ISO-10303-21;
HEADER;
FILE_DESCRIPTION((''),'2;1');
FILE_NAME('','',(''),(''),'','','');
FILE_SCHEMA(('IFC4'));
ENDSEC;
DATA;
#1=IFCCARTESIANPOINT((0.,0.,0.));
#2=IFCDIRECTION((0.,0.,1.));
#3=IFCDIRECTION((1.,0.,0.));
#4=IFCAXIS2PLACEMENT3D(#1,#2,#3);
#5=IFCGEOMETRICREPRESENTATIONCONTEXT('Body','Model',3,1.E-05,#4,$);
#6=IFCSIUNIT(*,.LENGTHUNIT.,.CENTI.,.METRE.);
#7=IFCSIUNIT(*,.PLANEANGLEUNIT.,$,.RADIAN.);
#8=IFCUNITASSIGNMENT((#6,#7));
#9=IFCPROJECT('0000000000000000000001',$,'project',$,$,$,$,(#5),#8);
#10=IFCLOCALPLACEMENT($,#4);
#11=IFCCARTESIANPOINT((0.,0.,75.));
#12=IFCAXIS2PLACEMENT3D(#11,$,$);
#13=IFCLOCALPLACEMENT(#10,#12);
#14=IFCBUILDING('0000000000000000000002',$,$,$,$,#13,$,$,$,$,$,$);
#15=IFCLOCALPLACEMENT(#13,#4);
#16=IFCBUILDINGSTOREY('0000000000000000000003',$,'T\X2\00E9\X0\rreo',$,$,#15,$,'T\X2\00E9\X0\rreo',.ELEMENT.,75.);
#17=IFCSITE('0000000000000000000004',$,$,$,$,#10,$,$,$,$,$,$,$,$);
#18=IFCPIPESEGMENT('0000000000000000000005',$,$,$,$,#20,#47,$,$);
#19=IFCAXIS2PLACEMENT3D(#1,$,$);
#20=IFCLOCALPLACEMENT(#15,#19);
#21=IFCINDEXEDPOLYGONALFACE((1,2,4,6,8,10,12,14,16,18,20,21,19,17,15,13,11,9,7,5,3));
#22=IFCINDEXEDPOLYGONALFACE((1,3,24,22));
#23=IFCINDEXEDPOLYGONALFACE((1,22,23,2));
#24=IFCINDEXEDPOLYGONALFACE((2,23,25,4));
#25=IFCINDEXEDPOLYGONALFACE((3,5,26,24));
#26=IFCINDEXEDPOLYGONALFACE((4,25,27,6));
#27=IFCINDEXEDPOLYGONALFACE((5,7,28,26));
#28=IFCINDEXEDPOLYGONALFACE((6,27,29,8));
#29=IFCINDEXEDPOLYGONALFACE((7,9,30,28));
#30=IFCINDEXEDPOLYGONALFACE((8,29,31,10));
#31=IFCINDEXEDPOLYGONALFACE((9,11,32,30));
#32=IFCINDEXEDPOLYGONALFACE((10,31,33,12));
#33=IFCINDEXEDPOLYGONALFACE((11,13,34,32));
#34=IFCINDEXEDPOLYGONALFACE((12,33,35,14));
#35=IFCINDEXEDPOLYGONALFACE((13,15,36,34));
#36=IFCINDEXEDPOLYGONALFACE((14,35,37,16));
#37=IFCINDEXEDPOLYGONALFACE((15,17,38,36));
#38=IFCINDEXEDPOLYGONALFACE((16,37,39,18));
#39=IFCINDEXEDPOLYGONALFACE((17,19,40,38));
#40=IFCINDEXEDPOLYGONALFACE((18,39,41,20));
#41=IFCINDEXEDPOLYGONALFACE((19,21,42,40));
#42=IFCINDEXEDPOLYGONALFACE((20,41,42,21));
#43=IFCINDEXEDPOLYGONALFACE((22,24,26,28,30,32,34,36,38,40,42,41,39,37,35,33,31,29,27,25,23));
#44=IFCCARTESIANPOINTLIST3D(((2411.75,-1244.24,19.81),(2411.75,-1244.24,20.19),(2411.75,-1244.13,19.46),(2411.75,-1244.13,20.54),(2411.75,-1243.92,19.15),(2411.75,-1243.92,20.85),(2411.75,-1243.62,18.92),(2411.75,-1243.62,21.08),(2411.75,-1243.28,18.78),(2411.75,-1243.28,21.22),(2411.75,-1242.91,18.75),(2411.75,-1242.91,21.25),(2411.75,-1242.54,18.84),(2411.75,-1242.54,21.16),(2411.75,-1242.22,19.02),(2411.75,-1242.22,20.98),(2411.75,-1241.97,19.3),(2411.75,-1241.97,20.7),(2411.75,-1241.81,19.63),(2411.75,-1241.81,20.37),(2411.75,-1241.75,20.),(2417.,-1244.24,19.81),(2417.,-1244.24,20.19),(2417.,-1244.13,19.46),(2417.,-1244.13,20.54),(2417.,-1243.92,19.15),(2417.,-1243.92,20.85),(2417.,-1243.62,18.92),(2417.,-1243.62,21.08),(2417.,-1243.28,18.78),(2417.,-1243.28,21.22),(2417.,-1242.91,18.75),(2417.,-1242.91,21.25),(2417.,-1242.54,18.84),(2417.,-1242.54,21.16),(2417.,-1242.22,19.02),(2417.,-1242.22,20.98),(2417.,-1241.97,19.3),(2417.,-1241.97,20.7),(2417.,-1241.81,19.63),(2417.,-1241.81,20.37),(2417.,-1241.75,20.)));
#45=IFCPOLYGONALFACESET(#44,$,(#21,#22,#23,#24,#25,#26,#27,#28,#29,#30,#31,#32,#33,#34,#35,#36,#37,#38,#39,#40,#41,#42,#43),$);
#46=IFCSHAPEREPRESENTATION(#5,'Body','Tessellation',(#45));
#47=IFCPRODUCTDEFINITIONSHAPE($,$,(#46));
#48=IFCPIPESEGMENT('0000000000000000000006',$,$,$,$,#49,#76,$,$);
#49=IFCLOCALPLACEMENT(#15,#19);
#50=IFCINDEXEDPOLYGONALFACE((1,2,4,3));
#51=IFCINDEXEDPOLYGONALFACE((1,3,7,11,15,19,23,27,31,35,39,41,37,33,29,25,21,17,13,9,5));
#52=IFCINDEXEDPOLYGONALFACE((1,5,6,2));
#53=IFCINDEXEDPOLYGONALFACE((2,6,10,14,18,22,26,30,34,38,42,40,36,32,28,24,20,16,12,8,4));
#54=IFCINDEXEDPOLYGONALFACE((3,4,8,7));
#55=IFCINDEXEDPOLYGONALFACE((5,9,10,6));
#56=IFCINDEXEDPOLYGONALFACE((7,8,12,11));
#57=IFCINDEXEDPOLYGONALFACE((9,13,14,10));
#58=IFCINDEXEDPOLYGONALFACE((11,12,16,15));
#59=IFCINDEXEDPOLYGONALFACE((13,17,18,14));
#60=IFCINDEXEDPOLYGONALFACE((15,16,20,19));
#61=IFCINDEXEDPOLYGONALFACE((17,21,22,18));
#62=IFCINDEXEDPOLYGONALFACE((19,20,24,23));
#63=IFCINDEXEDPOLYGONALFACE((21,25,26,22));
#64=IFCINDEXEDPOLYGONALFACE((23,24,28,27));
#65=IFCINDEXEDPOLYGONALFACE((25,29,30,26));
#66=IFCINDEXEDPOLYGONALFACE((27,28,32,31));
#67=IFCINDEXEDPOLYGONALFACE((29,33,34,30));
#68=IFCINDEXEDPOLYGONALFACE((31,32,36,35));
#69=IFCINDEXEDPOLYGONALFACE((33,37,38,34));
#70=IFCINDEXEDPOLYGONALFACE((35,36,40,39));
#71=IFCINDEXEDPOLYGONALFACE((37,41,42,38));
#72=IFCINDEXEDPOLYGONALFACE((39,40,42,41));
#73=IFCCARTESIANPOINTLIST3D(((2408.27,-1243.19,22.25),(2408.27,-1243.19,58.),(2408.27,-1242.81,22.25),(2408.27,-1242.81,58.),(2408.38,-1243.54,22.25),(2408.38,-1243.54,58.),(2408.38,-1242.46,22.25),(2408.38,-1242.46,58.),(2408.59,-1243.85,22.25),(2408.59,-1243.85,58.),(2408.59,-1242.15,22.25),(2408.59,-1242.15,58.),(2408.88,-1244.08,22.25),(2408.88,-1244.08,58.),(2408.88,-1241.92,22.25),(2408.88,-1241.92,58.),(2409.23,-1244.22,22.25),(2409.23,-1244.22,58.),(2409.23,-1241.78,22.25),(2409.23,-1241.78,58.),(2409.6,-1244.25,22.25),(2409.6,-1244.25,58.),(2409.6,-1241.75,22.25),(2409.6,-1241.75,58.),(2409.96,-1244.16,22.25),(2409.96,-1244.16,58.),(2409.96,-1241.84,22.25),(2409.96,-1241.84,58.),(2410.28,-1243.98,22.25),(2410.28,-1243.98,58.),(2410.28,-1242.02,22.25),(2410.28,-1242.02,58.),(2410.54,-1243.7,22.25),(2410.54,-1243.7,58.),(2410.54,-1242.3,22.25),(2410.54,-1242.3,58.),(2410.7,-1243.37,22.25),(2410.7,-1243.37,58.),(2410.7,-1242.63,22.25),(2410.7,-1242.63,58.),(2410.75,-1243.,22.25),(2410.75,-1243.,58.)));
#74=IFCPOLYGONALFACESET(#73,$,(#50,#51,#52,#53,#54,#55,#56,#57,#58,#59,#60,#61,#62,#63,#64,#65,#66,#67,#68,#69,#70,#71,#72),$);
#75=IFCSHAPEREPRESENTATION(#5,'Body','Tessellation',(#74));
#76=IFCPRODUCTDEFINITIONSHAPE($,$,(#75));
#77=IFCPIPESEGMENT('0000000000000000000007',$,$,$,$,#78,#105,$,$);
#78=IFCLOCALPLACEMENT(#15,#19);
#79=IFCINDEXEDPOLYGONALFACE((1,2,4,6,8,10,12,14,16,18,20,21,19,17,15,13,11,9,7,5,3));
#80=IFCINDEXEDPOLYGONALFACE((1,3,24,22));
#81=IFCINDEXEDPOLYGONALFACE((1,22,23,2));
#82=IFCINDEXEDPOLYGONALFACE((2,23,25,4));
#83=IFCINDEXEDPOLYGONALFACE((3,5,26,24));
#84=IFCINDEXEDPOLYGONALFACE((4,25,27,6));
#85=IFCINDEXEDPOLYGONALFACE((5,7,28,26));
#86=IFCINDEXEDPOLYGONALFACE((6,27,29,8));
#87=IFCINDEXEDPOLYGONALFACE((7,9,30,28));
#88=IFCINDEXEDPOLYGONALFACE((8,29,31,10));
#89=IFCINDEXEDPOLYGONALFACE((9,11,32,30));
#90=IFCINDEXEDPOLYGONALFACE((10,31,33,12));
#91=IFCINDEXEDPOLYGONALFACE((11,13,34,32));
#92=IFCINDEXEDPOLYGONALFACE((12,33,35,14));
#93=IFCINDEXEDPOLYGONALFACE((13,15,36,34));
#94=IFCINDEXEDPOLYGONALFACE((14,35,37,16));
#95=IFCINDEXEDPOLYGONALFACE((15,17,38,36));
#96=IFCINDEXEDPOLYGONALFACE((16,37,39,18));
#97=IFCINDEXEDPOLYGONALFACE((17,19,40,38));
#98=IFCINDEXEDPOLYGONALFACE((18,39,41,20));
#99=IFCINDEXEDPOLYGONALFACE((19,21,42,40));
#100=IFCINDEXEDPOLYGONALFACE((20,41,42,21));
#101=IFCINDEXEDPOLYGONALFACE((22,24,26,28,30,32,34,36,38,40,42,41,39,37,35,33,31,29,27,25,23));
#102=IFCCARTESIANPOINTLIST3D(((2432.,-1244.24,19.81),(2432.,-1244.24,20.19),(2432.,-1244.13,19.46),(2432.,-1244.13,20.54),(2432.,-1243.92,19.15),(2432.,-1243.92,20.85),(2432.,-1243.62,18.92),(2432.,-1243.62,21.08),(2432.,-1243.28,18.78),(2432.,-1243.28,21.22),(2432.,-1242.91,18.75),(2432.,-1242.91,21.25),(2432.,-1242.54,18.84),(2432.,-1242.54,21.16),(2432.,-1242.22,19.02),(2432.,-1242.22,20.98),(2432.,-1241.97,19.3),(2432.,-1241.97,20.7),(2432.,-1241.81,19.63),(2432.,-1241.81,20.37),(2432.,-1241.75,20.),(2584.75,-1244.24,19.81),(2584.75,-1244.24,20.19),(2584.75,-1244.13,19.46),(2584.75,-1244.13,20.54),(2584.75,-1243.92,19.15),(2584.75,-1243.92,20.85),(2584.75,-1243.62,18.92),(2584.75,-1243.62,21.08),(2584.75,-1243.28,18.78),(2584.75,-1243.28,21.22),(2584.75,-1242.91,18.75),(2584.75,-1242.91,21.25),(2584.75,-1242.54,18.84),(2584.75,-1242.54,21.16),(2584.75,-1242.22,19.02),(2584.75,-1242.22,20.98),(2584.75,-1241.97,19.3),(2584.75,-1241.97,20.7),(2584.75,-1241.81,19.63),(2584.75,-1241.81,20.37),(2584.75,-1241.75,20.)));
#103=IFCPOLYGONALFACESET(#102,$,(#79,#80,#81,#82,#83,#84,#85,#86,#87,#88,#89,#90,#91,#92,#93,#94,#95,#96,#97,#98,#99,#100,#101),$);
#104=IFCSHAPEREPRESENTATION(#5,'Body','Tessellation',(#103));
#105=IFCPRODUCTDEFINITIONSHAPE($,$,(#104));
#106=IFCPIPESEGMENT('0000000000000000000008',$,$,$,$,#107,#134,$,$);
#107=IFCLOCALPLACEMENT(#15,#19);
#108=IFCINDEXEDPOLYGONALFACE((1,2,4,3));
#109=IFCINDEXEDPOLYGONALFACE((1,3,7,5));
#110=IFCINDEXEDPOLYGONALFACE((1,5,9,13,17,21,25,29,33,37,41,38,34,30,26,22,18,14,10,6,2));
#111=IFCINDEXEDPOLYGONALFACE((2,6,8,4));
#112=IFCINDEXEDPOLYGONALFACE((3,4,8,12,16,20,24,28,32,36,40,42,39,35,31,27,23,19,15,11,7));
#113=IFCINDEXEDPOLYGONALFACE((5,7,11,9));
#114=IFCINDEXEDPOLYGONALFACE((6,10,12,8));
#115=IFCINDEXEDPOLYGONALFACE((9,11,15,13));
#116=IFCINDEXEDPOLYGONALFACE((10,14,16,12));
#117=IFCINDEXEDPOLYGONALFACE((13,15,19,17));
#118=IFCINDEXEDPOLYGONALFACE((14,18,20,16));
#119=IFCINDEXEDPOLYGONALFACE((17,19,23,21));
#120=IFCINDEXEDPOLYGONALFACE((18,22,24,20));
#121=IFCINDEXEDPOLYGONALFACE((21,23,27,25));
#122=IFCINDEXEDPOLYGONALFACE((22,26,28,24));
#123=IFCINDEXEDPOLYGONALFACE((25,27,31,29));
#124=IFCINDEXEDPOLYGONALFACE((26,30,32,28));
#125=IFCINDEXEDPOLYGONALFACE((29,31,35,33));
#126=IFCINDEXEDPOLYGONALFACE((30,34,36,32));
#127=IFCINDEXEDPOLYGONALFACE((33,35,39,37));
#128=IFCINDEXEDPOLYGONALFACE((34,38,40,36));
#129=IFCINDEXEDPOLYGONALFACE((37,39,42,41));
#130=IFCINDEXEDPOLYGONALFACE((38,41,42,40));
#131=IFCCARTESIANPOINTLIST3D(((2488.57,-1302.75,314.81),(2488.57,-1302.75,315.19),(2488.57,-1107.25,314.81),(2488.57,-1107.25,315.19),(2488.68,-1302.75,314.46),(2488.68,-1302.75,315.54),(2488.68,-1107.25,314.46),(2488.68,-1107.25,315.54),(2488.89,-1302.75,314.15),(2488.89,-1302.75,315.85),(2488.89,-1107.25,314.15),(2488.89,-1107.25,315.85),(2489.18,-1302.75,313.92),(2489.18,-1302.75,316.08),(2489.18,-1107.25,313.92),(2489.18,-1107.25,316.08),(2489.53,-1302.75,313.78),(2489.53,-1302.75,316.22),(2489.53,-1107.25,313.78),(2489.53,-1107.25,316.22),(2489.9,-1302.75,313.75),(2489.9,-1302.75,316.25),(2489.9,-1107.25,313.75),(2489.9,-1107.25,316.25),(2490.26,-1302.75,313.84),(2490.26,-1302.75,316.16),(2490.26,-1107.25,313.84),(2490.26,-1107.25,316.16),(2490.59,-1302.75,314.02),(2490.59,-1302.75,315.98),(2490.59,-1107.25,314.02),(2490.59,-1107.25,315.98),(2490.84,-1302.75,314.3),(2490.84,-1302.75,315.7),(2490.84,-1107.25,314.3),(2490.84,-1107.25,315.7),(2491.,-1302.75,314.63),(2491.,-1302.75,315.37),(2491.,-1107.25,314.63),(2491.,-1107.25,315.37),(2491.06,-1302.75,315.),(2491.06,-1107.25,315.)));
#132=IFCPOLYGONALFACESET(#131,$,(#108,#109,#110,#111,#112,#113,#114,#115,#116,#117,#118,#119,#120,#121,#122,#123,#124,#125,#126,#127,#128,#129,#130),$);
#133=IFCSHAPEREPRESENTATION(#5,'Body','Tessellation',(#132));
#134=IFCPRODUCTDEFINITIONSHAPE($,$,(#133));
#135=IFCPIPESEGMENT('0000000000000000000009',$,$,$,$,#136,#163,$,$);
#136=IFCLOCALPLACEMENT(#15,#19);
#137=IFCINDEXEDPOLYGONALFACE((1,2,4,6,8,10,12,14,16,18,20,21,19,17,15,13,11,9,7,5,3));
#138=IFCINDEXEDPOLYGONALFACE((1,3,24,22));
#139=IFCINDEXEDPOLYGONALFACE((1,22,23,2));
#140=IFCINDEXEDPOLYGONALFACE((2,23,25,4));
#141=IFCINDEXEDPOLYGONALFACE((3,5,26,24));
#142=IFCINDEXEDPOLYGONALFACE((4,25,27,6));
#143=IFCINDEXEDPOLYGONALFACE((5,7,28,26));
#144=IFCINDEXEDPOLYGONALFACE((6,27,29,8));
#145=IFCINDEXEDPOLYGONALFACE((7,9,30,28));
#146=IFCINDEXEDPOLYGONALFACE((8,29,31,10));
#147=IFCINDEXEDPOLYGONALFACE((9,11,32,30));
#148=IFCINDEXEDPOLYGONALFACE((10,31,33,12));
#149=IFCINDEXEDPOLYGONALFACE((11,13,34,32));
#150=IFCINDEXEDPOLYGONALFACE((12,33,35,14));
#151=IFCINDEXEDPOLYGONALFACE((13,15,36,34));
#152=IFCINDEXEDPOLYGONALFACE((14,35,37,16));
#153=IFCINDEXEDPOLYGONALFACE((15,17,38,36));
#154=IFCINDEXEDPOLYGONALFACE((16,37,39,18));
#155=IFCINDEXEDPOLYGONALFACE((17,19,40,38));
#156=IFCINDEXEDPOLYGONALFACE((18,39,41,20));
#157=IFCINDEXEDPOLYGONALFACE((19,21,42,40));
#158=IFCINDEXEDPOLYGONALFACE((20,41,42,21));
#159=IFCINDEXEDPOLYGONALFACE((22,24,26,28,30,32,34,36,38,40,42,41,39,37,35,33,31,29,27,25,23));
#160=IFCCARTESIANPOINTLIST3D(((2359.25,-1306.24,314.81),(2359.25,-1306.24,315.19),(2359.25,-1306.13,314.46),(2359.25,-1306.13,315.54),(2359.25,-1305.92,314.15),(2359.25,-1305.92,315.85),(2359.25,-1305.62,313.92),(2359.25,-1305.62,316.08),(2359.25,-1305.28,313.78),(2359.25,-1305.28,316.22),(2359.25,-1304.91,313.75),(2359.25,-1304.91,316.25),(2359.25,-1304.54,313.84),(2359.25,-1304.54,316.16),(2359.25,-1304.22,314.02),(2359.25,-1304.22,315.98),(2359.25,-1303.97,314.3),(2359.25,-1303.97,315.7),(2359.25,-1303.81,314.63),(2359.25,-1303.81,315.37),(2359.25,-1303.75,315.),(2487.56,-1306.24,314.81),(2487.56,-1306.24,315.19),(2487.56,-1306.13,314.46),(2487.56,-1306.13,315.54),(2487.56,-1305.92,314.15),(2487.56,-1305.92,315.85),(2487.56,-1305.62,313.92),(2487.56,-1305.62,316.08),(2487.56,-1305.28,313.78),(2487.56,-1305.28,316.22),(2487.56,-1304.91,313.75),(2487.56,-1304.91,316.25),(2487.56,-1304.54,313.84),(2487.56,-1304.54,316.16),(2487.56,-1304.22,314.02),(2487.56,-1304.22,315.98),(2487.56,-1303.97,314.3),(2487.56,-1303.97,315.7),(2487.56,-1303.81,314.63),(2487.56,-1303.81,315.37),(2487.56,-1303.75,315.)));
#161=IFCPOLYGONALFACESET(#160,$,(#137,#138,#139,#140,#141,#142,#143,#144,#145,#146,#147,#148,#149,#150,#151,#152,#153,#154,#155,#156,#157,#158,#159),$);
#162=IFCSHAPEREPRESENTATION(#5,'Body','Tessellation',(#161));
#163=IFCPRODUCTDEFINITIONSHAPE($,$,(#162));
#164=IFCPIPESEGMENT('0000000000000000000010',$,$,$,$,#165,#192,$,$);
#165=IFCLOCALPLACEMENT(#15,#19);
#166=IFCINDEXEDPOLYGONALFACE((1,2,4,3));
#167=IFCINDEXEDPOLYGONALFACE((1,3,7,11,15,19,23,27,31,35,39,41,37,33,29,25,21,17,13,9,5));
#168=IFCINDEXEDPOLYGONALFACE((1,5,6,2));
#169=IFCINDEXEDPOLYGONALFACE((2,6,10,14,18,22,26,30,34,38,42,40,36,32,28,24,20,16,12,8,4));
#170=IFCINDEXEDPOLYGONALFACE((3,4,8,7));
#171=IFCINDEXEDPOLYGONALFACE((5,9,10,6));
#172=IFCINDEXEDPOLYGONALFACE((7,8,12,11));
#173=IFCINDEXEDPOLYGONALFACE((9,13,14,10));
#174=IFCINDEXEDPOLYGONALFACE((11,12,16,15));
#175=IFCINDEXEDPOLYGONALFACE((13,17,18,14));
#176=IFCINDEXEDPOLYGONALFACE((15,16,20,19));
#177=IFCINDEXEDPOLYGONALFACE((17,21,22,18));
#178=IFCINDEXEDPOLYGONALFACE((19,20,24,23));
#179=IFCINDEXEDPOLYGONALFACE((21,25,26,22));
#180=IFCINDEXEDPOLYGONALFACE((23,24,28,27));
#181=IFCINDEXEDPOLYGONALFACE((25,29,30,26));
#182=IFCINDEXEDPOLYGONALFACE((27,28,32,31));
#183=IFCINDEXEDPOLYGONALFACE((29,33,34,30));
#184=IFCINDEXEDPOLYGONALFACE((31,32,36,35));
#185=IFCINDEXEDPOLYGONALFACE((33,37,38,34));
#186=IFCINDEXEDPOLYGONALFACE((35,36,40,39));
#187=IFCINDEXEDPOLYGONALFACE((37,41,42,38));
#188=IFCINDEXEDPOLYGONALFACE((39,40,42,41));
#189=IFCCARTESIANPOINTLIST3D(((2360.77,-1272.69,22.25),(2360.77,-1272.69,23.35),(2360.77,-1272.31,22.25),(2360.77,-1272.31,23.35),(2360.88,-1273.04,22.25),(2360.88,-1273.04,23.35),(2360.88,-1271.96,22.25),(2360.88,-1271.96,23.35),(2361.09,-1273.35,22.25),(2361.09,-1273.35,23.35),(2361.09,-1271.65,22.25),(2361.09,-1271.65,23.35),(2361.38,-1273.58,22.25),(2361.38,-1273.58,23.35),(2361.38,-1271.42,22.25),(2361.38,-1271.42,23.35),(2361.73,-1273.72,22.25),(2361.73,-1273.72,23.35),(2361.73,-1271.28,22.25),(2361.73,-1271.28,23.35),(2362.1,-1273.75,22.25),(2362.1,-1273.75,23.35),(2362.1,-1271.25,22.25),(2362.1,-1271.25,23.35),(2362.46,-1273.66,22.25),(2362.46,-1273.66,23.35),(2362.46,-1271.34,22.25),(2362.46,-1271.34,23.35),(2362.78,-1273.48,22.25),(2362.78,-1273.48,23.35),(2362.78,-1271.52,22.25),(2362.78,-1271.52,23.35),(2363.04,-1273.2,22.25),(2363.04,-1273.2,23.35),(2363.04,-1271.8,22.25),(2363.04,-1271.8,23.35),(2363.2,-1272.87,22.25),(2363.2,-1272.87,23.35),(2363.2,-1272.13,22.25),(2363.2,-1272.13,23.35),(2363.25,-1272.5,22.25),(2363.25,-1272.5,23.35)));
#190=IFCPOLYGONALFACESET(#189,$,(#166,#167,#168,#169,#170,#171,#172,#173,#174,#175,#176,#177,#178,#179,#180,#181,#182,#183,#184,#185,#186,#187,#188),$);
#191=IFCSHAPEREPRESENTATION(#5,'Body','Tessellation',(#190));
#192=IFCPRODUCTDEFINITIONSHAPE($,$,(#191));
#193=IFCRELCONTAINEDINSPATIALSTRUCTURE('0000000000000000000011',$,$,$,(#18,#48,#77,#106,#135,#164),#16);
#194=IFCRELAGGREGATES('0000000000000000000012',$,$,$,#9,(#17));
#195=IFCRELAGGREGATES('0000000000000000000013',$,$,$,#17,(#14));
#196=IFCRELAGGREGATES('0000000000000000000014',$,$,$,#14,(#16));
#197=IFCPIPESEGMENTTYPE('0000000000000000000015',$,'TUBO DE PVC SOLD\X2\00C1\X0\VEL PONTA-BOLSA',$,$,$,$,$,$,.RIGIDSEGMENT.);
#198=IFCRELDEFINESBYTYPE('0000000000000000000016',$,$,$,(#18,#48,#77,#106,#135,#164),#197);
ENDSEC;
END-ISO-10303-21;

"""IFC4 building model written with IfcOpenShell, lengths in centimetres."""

from ifc_helpers import new_model, si_unit, frame, origin_with_axes, origin_2d_with_axis, place, context, project, spatial, circle, extrude, type_object, element, save


model = new_model("IFC4")

# Units and contexts
model_context = context("Model", 3, precision=1e-05, world=origin_with_axes(), identifier="Body")
ifc_project = project(units=[si_unit("LENGTHUNIT", "METRE", prefix="CENTI"), si_unit("PLANEANGLEUNIT", "RADIAN")], contexts=[model_context])

# Site, building, storey
site_placement = place(None, origin_with_axes())
site = spatial("IfcSite", under=ifc_project, at=site_placement)
building_placement = place(site_placement, frame((0.0, 0.0, 75.0)))
building = spatial("IfcBuilding", under=site, at=building_placement)
storey_placement = place(building_placement, origin_with_axes())
storey = spatial("IfcBuildingStorey", under=building, at=storey_placement, Name="Térreo", LongName="Térreo", CompositionType="ELEMENT", Elevation=75.0)

# Pipe segments
pipe_segment_type_1 = type_object("IfcPipeSegmentType", Name="TUBO DE PVC SOLDÁVEL PONTA-BOLSA", PredefinedType="RIGIDSEGMENT")
pipe_segment_1_placement = place(storey_placement, frame((2414.38, -1243.0, 21.25), z_axis=(0.0, 0.0, 1.0), x_axis=(1.0, 0.0, 0.0)))
element("IfcPipeSegment", 1, at=pipe_segment_1_placement, inside=storey, type_object=pipe_segment_type_1, context=model_context, shape_type="SolidModel", body=[
    extrude(circle(Radius=1.25, at=origin_2d_with_axis()), frame((2.62, 0.0, -1.25), z_axis=(-1.0, 0.0, 0.0), x_axis=(0.0, 1.0, 0.0)), (0.0, 0.0, 1.0), 5.25),
])
pipe_segment_2_placement = place(storey_placement, frame((2409.5, -1243.0, 58.0), z_axis=(0.0, 0.0, 1.0), x_axis=(1.0, 0.0, 0.0)))
element("IfcPipeSegment", 2, at=pipe_segment_2_placement, inside=storey, type_object=pipe_segment_type_1, context=model_context, shape_type="SolidModel", body=[
    extrude(circle(Radius=1.25, at=origin_2d_with_axis()), frame((0.0, 0.0, -35.75), z_axis=(0.0, 0.0, 1.0), x_axis=(1.0, 0.0, 0.0)), (0.0, 0.0, 1.0), 35.75),
])
pipe_segment_3_placement = place(storey_placement, frame((2508.38, -1243.0, 21.25), z_axis=(0.0, 0.0, 1.0), x_axis=(1.0, 0.0, 0.0)))
element("IfcPipeSegment", 3, at=pipe_segment_3_placement, inside=storey, type_object=pipe_segment_type_1, context=model_context, shape_type="SolidModel", body=[
    extrude(circle(Radius=1.25, at=origin_2d_with_axis()), frame((76.38, 0.0, -1.25), z_axis=(-1.0, 0.0, 0.0), x_axis=(0.0, 1.0, 0.0)), (0.0, 0.0, 1.0), 152.75),
])
pipe_segment_4_placement = place(storey_placement, frame((2489.81, -1205.0, 316.25), z_axis=(0.0, 0.0, 1.0), x_axis=(1.0, 0.0, 0.0)))
element("IfcPipeSegment", 4, at=pipe_segment_4_placement, inside=storey, type_object=pipe_segment_type_1, context=model_context, shape_type="SolidModel", body=[
    extrude(circle(Radius=1.25, at=origin_2d_with_axis()), frame((0.0, -97.75, -1.25), z_axis=(0.0, 1.0, 0.0), x_axis=(1.0, 0.0, 0.0)), (0.0, 0.0, 1.0), 195.5),
])
pipe_segment_5_placement = place(storey_placement, frame((2423.41, -1305.0, 316.25), z_axis=(0.0, 0.0, 1.0), x_axis=(1.0, 0.0, 0.0)))
element("IfcPipeSegment", 5, at=pipe_segment_5_placement, inside=storey, type_object=pipe_segment_type_1, context=model_context, shape_type="SolidModel", body=[
    extrude(circle(Radius=1.25, at=origin_2d_with_axis()), frame((-64.15, 0.0, -1.25), z_axis=(1.0, 0.0, 0.0), x_axis=(0.0, 1.0, 0.0)), (0.0, 0.0, 1.0), 128.3),
])
pipe_segment_6_placement = place(storey_placement, frame((2362.0, -1272.5, 23.35), z_axis=(0.0, 0.0, 1.0), x_axis=(1.0, 0.0, 0.0)))
element("IfcPipeSegment", 6, at=pipe_segment_6_placement, inside=storey, type_object=pipe_segment_type_1, context=model_context, shape_type="SolidModel", body=[
    extrude(circle(Radius=1.25, at=origin_2d_with_axis()), frame((0.0, 0.0, -1.1), z_axis=(0.0, 0.0, 1.0), x_axis=(1.0, 0.0, 0.0)), (0.0, 0.0, 1.0), 1.1),
])

save(model, "model.ifc")
